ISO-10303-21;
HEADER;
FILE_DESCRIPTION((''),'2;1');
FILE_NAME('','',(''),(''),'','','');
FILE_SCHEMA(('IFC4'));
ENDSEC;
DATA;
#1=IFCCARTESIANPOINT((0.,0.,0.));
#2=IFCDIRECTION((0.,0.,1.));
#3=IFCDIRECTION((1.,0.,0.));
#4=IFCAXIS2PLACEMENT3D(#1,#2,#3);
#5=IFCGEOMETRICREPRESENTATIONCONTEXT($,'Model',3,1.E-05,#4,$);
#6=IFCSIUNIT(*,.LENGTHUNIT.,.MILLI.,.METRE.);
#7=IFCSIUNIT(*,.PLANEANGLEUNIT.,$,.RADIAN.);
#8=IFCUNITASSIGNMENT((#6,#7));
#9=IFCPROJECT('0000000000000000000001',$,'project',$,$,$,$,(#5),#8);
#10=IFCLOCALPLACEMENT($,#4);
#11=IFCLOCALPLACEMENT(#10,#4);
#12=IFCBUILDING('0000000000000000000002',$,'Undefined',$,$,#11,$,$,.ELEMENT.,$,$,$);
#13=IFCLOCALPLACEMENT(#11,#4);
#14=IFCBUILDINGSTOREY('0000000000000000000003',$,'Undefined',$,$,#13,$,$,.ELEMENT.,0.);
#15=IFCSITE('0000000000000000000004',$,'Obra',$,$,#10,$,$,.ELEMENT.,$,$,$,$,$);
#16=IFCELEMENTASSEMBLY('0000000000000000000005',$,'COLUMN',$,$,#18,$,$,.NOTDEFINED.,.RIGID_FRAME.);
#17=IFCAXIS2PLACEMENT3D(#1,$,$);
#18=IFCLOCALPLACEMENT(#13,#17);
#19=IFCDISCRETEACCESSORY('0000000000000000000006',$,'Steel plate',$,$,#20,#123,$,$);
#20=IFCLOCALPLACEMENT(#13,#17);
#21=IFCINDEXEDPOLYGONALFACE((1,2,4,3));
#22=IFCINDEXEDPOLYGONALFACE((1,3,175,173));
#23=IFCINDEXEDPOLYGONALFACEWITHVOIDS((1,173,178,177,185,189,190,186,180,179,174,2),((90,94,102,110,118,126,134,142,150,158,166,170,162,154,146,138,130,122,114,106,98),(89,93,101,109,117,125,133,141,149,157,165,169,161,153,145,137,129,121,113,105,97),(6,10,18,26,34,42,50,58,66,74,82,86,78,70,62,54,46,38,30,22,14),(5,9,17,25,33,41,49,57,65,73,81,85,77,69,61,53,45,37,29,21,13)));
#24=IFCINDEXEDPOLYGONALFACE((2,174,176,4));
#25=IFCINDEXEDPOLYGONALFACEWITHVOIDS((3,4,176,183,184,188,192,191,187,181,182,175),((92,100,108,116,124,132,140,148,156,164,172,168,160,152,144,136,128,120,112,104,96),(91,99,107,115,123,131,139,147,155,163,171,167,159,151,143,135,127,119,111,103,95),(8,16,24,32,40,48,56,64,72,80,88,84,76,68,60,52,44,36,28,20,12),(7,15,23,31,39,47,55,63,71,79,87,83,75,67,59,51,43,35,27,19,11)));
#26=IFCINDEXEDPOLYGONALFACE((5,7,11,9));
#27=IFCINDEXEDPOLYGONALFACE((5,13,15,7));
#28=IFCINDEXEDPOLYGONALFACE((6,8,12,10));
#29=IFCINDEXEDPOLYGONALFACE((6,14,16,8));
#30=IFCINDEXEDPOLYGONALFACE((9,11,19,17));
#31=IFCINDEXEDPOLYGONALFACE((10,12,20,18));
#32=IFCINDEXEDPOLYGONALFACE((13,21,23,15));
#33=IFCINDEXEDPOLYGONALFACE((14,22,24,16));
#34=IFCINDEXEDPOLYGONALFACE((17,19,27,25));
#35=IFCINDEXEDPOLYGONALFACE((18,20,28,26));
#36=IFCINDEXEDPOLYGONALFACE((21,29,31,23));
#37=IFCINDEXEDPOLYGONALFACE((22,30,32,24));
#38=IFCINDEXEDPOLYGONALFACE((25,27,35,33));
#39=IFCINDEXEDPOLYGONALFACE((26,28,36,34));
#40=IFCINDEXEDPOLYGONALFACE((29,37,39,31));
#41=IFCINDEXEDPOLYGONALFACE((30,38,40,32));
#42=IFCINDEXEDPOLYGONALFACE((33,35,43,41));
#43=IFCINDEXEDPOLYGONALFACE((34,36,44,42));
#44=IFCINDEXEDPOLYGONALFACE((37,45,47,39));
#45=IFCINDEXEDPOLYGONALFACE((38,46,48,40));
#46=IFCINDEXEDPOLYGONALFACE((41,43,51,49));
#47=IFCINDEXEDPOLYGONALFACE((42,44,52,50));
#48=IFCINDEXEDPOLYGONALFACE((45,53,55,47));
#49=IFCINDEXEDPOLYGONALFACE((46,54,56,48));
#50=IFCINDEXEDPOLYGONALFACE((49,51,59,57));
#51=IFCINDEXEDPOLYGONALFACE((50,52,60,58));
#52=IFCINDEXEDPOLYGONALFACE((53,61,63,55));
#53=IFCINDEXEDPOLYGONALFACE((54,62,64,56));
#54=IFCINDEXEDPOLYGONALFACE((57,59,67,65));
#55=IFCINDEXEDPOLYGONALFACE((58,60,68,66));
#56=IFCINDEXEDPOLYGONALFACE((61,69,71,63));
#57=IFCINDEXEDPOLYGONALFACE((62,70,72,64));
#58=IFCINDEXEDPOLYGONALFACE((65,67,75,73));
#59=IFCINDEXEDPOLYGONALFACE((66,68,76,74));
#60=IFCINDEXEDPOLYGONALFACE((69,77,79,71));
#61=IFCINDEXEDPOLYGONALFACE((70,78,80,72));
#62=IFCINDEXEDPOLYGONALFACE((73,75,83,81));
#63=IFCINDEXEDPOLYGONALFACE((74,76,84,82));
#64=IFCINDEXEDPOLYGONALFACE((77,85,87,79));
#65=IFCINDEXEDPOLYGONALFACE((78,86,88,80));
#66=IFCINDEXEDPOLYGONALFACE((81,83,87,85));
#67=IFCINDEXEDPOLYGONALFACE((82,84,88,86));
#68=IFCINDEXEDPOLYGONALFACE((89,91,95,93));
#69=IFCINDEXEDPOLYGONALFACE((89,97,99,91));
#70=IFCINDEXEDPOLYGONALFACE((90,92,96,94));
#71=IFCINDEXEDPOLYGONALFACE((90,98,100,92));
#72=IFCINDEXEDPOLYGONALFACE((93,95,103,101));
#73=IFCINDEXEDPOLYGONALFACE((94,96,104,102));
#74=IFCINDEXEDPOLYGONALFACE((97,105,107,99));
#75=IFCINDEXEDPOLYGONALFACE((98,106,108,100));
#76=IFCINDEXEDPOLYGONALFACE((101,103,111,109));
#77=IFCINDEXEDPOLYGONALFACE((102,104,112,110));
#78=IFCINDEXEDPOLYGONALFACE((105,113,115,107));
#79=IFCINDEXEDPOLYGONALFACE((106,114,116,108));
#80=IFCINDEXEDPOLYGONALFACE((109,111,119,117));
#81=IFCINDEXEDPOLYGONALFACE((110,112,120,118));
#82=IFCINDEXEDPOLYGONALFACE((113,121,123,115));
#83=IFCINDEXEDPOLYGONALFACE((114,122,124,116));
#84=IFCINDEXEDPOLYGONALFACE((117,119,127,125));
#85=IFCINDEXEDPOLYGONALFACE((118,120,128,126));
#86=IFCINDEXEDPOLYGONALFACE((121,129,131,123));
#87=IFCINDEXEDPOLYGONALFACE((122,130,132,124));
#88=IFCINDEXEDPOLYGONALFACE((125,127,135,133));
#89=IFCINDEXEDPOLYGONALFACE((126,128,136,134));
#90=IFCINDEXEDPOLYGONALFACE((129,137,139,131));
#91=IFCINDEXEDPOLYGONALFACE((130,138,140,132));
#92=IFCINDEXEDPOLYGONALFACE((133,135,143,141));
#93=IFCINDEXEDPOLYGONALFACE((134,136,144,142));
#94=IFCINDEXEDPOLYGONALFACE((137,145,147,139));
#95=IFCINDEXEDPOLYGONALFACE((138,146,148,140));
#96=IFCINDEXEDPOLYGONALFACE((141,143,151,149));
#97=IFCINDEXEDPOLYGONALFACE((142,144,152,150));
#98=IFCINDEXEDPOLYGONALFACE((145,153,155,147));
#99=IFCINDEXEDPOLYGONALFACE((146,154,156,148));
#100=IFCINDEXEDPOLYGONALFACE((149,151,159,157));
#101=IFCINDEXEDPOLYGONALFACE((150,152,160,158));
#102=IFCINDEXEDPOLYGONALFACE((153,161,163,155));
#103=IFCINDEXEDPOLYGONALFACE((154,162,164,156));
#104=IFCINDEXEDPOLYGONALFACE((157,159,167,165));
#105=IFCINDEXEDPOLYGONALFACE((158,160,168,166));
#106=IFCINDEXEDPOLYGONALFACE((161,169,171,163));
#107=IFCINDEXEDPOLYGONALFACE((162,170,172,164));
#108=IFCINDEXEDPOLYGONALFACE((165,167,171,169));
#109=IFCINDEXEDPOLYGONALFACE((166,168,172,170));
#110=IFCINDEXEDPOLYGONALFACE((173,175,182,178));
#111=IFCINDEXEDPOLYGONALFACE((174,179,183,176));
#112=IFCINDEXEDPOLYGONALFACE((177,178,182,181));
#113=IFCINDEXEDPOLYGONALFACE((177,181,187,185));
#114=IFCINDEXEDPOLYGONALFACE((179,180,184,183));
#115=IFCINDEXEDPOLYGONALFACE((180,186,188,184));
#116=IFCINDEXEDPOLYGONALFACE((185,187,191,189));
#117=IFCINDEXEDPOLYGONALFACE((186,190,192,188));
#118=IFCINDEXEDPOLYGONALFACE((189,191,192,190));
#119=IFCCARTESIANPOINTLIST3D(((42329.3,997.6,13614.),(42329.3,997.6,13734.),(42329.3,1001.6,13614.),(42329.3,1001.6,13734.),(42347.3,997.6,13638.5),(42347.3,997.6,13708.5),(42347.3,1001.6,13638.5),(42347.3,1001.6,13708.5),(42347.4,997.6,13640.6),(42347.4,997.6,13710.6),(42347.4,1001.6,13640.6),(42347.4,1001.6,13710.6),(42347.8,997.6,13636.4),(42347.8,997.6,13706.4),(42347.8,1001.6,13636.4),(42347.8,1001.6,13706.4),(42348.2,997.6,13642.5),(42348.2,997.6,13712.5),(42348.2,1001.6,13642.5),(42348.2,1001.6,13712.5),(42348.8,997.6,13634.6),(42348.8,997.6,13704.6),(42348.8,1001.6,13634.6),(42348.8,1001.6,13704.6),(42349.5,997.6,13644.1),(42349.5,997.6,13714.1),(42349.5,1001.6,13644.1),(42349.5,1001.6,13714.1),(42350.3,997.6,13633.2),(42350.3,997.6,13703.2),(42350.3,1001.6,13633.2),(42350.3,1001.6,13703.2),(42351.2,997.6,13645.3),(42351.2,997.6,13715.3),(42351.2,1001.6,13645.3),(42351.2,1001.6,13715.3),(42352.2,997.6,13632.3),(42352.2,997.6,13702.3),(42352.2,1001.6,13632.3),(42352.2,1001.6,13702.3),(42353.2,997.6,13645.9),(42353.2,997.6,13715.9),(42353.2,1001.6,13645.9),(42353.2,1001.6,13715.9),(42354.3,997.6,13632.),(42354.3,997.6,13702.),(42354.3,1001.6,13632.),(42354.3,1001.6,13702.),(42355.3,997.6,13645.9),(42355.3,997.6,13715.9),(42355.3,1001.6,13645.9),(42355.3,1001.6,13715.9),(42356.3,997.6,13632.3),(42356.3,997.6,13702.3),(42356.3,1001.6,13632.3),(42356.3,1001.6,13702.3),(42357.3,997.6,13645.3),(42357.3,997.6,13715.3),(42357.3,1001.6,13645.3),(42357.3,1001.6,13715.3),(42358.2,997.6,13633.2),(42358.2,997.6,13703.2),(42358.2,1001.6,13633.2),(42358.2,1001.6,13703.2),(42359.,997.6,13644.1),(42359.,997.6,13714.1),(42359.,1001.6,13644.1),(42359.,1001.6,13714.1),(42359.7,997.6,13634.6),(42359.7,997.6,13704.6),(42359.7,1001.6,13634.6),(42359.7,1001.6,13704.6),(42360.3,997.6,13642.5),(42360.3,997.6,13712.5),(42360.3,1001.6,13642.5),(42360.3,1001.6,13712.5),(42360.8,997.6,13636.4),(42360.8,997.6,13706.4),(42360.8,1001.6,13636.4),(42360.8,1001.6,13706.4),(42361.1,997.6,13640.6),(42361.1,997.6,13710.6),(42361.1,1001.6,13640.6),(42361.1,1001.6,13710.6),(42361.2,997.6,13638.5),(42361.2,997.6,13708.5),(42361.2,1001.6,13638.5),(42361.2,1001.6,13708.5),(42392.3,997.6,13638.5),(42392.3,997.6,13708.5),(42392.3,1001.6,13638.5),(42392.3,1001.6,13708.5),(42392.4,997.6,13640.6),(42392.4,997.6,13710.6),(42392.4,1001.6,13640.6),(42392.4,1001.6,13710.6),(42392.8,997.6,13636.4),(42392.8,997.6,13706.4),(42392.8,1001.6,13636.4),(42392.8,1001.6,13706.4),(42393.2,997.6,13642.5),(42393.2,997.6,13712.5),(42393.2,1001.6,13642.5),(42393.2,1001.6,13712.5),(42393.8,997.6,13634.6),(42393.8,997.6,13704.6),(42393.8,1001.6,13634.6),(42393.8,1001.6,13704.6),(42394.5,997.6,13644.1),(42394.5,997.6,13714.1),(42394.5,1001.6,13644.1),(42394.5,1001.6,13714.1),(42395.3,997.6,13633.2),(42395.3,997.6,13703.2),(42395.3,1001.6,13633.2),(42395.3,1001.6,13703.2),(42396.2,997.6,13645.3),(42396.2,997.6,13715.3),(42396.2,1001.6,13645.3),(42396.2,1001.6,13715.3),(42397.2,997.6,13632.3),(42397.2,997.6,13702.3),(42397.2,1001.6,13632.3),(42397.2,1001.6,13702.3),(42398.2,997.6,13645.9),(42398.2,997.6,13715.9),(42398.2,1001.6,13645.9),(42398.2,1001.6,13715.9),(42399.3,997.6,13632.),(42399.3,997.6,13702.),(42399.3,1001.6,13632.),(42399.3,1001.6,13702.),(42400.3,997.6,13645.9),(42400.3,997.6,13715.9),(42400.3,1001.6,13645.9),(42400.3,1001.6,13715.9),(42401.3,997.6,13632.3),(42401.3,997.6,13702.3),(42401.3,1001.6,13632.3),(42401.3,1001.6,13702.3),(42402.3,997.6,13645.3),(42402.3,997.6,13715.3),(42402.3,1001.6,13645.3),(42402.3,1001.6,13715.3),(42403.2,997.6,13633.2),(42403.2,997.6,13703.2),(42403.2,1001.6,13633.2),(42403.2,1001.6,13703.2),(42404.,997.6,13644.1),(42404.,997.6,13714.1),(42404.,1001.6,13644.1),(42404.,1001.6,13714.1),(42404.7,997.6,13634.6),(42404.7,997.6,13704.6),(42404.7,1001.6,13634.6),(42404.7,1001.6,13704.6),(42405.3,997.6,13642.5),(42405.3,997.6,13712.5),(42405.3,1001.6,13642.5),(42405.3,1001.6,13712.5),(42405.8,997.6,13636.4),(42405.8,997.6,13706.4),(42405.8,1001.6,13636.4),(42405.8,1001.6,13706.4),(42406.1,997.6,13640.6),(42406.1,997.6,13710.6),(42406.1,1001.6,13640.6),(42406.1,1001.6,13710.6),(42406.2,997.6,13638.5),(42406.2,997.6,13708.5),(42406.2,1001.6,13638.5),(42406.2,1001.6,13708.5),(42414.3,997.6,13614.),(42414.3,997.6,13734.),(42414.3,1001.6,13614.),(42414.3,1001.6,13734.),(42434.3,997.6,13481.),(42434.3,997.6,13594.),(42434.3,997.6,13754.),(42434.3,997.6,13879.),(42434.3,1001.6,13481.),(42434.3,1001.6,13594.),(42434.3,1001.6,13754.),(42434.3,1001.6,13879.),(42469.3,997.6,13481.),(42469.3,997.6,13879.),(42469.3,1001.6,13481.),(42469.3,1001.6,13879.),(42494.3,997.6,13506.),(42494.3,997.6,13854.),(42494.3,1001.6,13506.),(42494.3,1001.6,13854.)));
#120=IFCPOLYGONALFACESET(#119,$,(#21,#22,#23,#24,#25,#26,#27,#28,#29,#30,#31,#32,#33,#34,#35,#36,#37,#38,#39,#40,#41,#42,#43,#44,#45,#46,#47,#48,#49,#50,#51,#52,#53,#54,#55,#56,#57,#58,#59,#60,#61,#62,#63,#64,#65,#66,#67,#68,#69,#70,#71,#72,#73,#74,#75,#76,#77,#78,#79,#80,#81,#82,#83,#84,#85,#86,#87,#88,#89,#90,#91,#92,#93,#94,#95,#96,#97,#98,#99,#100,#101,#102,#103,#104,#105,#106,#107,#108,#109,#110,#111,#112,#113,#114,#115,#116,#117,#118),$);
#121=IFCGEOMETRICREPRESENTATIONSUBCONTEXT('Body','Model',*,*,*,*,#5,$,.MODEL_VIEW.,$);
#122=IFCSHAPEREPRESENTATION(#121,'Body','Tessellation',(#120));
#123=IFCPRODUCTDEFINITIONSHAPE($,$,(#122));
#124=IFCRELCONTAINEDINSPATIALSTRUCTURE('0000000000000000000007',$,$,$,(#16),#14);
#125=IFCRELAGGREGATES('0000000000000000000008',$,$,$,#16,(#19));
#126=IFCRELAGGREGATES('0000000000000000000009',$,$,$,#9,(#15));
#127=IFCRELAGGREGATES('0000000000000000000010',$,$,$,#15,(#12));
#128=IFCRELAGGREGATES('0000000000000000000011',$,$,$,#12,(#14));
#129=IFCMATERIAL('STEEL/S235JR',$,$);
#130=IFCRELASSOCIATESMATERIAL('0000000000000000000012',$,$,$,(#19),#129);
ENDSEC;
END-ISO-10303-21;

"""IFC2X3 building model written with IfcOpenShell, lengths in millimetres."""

from ifc_helpers import new_model, si_unit, frame, origin_with_axes, origin_2d_with_axis, place, context, subcontext, project, spatial, polyline, circle, outline, extrude, source, transform, mapped, material, element, aggregate, save


model = new_model("IFC2X3")

# Units and contexts
model_context = context("Model", 3, precision=1e-05, world=origin_with_axes())
body_context = subcontext(model_context, "Body", "Model", "MODEL_VIEW")
ifc_project = project(units=[si_unit("LENGTHUNIT", "METRE", prefix="MILLI"), si_unit("PLANEANGLEUNIT", "RADIAN")], contexts=[model_context])

# Site, building, storey
site_placement = place(None, origin_with_axes())
site = spatial("IfcSite", under=ifc_project, at=site_placement, Name="Obra", CompositionType="ELEMENT")
building_placement = place(site_placement, origin_with_axes())
building = spatial("IfcBuilding", under=site, at=building_placement, Name="Undefined", CompositionType="ELEMENT")
storey_placement = place(building_placement, origin_with_axes())
storey = spatial("IfcBuildingStorey", under=building, at=storey_placement, Name="Undefined", CompositionType="ELEMENT", Elevation=0.0)

# Element assembly
assembly_1_placement = place(storey_placement, origin_with_axes())
assembly_1 = element("IfcElementAssembly", 1, at=assembly_1_placement, inside=storey, Name="COLUMN", AssemblyPlace="NOTDEFINED", PredefinedType="RIGID_FRAME")
ifc_material_1 = material(Name="STEEL/S235JR")

# Discrete accessory, opening
discrete_accessory_1_placement = place(assembly_1_placement, frame((42494.3, 999.6, 13506.0), z_axis=(0.000024, 1.0, 0.0), x_axis=(-0.707107, 0.000016, -0.707107)))
discrete_accessory_1 = element("IfcDiscreteAccessory", 2, at=discrete_accessory_1_placement, material=ifc_material_1, Name="Steel plate", context=body_context, shape_type="SweptSolid", body=[
    extrude(outline(polyline([(0.0, 0.0), (35.4, 0.0), (60.1, 24.7), (-19.8, 104.7), (-19.8, 132.9), (40.3, 193.0), (-44.5, 277.9), (-104.7, 217.8), (-132.9, 217.8), (-221.3, 306.2), (-246.1, 281.4), (-246.1, 246.1), (0.0, 0.0)])), frame((0.0, 0.0, -2.0), z_axis=(0.0, 0.0, 1.0), x_axis=(1.0, 0.0, 0.0)), (0.0, 0.0, 1.0), 4.0),
])
shared_shape_1 = source(origin_with_axes(), body_context, "Body", "SweptSolid", [
    extrude(circle(Radius=7.0, at=origin_2d_with_axis()), frame((0.0, 32.4, 0.0), z_axis=(0.0, 1.0, 0.0), x_axis=(1.0, 0.0, 0.0)), (0.0, 0.0, 1.0), 4.2),
])
opening_1_placement = place(assembly_1_placement, frame((42424.3, 1034.1, 13734.0), z_axis=(-1.0, 0.000022, 0.0), x_axis=(0.0, 0.0, -1.0)))
element("IfcOpeningElement", 3, at=opening_1_placement, cuts=discrete_accessory_1, ObjectType="Opening", context=body_context, shape_type="MappedRepresentation", body=[
    mapped(shared_shape_1, transform((25.0, 0.0, 25.0))),
    mapped(shared_shape_1, transform((25.0, 0.0, 70.0))),
    mapped(shared_shape_1, transform((95.0, 0.0, 25.0))),
    mapped(shared_shape_1, transform((95.0, 0.0, 70.0))),
])
aggregate(assembly_1, [discrete_accessory_1])

save(model, "model.ifc")
